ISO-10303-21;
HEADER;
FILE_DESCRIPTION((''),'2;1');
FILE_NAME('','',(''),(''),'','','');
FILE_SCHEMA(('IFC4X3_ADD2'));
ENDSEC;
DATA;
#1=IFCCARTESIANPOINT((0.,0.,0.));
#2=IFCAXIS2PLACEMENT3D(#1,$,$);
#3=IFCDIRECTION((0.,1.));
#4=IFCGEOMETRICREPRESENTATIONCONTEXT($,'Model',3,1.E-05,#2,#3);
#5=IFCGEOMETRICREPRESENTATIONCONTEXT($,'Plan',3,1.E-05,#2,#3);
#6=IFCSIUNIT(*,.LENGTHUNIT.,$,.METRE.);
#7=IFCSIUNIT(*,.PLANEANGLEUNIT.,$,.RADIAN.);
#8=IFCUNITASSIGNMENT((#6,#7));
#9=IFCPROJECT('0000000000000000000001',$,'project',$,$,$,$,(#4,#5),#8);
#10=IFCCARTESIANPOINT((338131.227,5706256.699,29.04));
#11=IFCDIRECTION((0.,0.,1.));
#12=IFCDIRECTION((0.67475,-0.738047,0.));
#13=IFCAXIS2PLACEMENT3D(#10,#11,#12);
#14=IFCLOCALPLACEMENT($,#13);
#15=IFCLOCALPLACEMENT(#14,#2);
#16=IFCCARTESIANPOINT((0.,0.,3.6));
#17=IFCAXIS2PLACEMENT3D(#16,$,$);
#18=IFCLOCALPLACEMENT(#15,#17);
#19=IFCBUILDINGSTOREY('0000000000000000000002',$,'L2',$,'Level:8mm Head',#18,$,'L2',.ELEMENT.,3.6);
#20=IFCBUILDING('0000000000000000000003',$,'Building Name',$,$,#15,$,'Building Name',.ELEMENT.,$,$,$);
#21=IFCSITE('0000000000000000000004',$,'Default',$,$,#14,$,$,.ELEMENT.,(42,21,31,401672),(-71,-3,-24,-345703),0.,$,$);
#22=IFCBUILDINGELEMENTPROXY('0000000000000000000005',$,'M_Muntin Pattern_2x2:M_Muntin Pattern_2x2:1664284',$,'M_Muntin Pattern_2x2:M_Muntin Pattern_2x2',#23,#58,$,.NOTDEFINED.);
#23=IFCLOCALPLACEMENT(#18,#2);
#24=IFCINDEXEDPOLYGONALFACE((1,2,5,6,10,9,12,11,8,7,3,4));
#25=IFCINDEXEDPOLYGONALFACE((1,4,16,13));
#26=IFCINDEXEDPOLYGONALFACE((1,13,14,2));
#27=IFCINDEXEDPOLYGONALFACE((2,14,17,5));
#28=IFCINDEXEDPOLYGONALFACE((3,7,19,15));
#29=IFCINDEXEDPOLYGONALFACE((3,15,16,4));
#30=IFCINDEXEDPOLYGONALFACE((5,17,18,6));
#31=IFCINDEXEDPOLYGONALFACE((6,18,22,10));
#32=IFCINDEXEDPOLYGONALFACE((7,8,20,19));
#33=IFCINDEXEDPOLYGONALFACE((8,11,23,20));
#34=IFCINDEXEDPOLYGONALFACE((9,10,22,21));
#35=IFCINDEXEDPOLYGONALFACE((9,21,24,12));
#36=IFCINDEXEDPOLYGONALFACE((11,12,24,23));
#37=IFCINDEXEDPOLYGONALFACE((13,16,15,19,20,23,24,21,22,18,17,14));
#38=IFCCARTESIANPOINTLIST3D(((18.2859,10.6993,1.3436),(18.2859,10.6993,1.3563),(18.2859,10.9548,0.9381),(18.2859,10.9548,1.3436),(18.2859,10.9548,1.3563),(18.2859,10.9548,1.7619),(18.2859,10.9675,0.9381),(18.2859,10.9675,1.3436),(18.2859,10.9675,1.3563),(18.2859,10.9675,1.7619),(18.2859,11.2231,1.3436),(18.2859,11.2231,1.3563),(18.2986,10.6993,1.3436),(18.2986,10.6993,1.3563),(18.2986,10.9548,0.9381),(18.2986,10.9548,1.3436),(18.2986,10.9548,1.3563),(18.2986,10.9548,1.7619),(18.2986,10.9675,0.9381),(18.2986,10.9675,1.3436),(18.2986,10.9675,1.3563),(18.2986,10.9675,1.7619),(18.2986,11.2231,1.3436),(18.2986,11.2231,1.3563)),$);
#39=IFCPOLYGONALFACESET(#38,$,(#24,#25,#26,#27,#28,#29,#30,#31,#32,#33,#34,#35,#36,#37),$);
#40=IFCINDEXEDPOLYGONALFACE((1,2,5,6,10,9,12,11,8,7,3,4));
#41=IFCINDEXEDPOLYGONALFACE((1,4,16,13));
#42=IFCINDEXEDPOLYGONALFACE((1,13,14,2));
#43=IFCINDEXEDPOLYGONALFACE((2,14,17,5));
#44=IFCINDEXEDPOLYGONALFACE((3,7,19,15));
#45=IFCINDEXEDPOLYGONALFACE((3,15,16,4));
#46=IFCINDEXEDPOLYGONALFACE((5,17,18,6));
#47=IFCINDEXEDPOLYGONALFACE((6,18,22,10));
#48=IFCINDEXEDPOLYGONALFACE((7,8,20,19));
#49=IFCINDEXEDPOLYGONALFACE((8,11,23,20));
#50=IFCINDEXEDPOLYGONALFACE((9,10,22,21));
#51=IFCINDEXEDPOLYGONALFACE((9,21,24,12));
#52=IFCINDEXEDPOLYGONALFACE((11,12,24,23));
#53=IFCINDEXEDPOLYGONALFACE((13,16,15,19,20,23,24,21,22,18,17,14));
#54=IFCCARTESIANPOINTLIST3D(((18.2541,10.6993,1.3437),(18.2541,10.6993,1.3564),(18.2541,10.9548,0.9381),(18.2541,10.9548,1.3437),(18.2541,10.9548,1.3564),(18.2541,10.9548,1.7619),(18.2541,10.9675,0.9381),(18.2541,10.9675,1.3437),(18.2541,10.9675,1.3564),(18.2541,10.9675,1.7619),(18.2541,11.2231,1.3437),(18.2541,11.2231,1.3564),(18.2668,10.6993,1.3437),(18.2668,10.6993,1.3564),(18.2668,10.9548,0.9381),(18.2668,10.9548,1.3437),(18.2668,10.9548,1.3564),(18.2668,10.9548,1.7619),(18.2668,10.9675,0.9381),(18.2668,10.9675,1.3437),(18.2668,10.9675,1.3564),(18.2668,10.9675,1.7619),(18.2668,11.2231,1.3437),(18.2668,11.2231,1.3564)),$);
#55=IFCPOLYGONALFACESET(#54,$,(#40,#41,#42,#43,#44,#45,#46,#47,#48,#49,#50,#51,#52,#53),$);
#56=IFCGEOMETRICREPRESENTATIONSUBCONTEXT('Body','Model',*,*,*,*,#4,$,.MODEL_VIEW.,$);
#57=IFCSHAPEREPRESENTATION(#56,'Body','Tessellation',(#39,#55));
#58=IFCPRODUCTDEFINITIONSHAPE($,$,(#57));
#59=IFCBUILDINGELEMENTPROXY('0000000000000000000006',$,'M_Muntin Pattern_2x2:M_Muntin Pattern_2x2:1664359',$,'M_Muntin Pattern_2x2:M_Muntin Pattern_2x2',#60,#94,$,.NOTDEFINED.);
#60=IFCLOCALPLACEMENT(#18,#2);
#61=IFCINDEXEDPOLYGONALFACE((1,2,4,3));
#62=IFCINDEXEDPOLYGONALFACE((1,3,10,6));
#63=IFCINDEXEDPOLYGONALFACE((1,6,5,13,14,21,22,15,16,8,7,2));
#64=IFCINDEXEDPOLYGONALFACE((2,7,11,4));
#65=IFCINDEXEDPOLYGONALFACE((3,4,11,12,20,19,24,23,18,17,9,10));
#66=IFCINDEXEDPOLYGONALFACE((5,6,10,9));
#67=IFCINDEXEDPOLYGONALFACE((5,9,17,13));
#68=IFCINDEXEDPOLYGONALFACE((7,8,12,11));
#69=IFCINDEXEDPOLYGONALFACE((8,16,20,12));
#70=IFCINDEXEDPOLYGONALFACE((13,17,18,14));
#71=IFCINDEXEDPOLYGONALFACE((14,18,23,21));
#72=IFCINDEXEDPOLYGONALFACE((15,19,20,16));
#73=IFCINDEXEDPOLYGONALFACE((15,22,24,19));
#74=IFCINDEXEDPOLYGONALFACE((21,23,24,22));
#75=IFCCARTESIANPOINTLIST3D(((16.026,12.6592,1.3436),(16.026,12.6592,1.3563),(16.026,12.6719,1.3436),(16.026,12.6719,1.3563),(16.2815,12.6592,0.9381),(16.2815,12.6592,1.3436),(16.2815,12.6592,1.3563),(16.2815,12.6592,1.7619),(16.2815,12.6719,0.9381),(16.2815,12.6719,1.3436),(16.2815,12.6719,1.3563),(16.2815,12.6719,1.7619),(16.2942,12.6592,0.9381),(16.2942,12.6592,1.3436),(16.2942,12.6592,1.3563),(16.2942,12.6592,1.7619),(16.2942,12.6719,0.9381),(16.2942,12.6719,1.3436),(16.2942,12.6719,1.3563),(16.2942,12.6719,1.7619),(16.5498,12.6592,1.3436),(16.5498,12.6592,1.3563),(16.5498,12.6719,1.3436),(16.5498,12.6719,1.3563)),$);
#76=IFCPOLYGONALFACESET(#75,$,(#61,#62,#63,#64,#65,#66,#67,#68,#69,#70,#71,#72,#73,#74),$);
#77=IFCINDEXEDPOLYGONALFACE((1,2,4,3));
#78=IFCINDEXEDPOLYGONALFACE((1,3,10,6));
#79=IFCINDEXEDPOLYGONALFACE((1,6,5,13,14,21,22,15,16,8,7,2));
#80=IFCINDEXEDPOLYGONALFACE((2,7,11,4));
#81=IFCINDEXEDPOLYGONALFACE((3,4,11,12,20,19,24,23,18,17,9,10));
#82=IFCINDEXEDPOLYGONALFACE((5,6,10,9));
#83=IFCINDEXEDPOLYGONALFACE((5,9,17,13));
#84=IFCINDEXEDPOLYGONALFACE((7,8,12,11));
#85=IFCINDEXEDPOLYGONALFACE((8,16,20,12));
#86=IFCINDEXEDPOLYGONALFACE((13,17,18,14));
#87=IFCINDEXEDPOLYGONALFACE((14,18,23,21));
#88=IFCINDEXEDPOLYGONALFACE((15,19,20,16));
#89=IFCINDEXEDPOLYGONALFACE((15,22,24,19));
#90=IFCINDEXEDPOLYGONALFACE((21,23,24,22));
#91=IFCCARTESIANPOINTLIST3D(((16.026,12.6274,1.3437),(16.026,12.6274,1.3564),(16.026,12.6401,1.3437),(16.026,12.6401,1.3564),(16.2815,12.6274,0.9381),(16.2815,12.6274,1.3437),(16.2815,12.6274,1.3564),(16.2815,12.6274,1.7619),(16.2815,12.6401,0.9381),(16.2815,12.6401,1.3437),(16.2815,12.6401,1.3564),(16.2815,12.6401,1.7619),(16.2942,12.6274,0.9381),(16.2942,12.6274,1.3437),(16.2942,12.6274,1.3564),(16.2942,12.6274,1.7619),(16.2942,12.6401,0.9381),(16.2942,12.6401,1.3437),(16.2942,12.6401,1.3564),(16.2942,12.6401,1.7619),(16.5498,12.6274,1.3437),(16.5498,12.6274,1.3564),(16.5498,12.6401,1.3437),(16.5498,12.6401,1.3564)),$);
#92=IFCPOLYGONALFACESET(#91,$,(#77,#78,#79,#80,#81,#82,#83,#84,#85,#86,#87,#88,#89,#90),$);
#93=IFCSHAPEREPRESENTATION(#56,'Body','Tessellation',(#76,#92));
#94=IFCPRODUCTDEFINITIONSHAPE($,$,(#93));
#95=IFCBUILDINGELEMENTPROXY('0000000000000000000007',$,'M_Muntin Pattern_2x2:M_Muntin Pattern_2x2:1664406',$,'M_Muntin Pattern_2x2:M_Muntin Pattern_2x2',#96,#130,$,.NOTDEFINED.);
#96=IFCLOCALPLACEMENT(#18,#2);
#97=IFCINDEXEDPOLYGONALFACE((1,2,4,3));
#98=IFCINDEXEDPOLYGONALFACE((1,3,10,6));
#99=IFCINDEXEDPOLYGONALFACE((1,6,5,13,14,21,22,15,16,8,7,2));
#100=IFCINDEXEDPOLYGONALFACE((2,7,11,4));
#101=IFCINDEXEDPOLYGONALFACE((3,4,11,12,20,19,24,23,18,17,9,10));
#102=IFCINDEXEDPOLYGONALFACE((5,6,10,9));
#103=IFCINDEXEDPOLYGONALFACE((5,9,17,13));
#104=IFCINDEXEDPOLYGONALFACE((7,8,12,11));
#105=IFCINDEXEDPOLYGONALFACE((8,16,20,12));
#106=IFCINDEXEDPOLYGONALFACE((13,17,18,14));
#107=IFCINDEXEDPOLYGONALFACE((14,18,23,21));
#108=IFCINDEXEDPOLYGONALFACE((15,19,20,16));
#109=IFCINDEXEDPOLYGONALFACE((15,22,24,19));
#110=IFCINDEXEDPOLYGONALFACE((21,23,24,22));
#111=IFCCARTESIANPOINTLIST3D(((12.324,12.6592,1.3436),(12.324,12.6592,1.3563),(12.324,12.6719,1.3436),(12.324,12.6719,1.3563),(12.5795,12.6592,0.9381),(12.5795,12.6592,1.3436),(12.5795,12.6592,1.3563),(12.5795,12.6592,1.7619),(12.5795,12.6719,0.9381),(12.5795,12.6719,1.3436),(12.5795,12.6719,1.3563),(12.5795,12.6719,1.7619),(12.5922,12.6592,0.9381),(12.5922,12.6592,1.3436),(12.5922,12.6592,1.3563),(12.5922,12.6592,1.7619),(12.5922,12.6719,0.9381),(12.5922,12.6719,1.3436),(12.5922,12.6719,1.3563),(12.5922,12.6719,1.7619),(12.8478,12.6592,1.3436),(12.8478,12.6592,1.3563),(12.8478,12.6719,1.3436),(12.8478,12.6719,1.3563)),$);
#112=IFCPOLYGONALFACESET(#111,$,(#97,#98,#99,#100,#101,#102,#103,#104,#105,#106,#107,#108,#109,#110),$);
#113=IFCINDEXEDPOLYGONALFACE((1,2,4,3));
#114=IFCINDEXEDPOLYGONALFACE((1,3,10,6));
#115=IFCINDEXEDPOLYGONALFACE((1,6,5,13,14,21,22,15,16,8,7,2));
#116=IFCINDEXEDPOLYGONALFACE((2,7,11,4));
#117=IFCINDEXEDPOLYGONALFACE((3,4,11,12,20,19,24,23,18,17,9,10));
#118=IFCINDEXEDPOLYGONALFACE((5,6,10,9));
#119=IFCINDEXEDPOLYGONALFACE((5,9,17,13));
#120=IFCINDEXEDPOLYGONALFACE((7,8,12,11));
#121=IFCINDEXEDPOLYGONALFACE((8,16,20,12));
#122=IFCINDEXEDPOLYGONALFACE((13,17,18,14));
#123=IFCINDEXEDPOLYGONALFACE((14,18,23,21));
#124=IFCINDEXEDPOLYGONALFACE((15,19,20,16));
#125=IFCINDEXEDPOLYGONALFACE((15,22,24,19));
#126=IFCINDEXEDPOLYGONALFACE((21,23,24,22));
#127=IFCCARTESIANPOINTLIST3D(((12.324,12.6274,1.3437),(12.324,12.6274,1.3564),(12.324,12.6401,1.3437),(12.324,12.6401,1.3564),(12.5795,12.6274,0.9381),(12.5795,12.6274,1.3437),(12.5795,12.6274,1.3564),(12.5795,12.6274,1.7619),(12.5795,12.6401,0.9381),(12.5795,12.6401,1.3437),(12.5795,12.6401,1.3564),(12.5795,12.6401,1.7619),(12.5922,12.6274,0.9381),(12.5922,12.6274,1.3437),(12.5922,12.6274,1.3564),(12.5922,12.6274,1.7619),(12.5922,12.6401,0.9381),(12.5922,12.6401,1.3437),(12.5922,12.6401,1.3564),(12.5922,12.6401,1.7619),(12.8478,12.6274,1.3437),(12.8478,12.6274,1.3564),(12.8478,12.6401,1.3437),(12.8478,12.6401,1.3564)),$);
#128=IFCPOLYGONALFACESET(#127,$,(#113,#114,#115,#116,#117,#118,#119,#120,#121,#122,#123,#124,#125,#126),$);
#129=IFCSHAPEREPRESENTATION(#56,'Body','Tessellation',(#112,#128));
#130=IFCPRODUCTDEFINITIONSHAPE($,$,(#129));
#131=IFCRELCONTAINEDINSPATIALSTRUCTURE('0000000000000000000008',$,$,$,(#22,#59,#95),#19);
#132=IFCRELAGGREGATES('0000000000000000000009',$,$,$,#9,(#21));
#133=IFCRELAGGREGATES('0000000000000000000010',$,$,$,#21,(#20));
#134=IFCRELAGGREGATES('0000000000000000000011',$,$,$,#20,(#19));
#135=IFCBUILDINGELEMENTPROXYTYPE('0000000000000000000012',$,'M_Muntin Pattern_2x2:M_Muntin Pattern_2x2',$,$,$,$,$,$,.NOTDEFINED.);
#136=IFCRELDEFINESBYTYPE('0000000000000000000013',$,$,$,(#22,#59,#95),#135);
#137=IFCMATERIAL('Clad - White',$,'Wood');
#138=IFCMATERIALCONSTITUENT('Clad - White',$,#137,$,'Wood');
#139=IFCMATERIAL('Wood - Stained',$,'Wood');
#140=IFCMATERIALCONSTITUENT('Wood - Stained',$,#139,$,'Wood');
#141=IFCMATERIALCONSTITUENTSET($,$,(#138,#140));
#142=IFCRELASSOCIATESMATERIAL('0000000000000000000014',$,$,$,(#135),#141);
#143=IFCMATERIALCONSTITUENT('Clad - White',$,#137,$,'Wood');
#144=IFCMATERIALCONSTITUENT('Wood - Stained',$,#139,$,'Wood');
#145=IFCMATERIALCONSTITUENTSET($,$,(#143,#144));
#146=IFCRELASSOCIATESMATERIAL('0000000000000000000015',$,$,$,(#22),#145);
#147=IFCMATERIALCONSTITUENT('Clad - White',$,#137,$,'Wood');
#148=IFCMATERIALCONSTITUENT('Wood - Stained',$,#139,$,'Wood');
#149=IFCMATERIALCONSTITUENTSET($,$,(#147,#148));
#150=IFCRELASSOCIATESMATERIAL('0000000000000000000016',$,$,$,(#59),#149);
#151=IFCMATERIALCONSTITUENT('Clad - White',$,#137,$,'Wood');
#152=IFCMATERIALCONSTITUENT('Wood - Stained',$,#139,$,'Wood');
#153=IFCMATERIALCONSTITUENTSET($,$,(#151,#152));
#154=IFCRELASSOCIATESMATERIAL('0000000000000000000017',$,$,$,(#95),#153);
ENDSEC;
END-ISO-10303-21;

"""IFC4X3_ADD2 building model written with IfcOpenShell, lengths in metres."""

from ifc_helpers import new_model, si_unit, direction, frame, origin, place, context, subcontext, project, spatial, polyline, outline, extrude, source, transform, mapped, material, constituent, constituent_set, type_object, type_shapes, element, save


model = new_model("IFC4X3_ADD2")

# Units and contexts
model_context = context("Model", 3, precision=1e-05, world=origin(), true_north=direction((0.0, 1.0)))
plan_context = context("Plan", 3, precision=1e-05, world=origin(), true_north=direction((0.0, 1.0)))
body_context = subcontext(model_context, "Body", "Model", "MODEL_VIEW")
ifc_project = project(units=[si_unit("LENGTHUNIT", "METRE"), si_unit("PLANEANGLEUNIT", "RADIAN")], contexts=[model_context, plan_context])

# Site, building, storey
site_placement = place(None, frame((338131.227, 5706256.699, 29.04), z_axis=(0.0, 0.0, 1.0), x_axis=(0.67475, -0.738047, 0.0)))
site = spatial("IfcSite", under=ifc_project, at=site_placement, Name="Default", CompositionType="ELEMENT", RefLatitude=(42, 21, 31, 401672), RefLongitude=(-71, -3, -24, -345703), RefElevation=0.0)
building_placement = place(site_placement, origin())
building = spatial("IfcBuilding", under=site, at=building_placement, Name="Building Name", LongName="Building Name", CompositionType="ELEMENT")
storey_placement = place(building_placement, frame((0.0, 0.0, 3.6)))
storey = spatial("IfcBuildingStorey", under=building, at=storey_placement, Name="L2", ObjectType="Level:8mm Head", LongName="L2", CompositionType="ELEMENT", Elevation=3.6)

# Building element proxies
ifc_material_1 = material(Name="Clad - White", Category="Wood")
ifc_material_2 = material(Name="Wood - Stained", Category="Wood")
ifc_constituent_1 = constituent(ifc_material_1, Name="Clad - White", Category="Wood")
ifc_constituent_2 = constituent(ifc_material_2, Name="Wood - Stained", Category="Wood")
ifc_constituent_set_1 = constituent_set(constituents=[ifc_constituent_1, ifc_constituent_2])
building_element_proxy_type = type_object("IfcBuildingElementProxyType", Name="M_Muntin Pattern_2x2:M_Muntin Pattern_2x2", PredefinedType="NOTDEFINED", material=ifc_constituent_set_1)
shared_shape = source(origin(), body_context, "Body", "SweptSolid", [
    extrude(outline(polyline([(0.0064, -0.0064), (0.4119, -0.0064), (0.4119, 0.0063), (0.0064, 0.0063), (0.0064, 0.2619), (-0.0063, 0.2619), (-0.0063, 0.0063), (-0.4119, 0.0063), (-0.4119, -0.0064), (-0.0063, -0.0064), (-0.0063, -0.2619), (0.0064, -0.2619), (0.0064, -0.0064)])), frame((0.0, -0.0222, 0.4119), z_axis=(0.0, 1.0, 0.0), x_axis=(0.0, 0.0, 1.0)), (0.0, 0.0, 1.0), 0.0127),
    extrude(outline(polyline([(0.0064, -0.0064), (0.4119, -0.0064), (0.4119, 0.0063), (0.0064, 0.0063), (0.0064, 0.2619), (-0.0063, 0.2619), (-0.0063, 0.0063), (-0.4119, 0.0063), (-0.4119, -0.0064), (-0.0063, -0.0064), (-0.0063, -0.2619), (0.0064, -0.2619), (0.0064, -0.0064)])), frame((0.0, 0.0095, 0.4119), z_axis=(0.0, 1.0, 0.0), x_axis=(0.0, 0.0, 1.0)), (0.0, 0.0, 1.0), 0.0127),
])
type_shapes(building_element_proxy_type, [shared_shape])
ifc_constituent_3 = constituent(ifc_material_1, Name="Clad - White", Category="Wood")
ifc_constituent_4 = constituent(ifc_material_2, Name="Wood - Stained", Category="Wood")
ifc_constituent_set_2 = constituent_set(constituents=[ifc_constituent_3, ifc_constituent_4])
proxy_1_placement = place(storey_placement, frame((18.2763, 10.9612, 0.9381), z_axis=(0.0, 0.0, 1.0), x_axis=(0.0, 1.0, 0.0)))
element("IfcBuildingElementProxy", 1, at=proxy_1_placement, inside=storey, type_object=building_element_proxy_type, material=ifc_constituent_set_2, Name="M_Muntin Pattern_2x2:M_Muntin Pattern_2x2:1664284", ObjectType="M_Muntin Pattern_2x2:M_Muntin Pattern_2x2", PredefinedType="NOTDEFINED", context=body_context, shape_type="MappedRepresentation", body=[
    mapped(shared_shape, transform((0.0, 0.0, 0.0), scale=1.0)),
])
ifc_constituent_5 = constituent(ifc_material_1, Name="Clad - White", Category="Wood")
ifc_constituent_6 = constituent(ifc_material_2, Name="Wood - Stained", Category="Wood")
ifc_constituent_set_3 = constituent_set(constituents=[ifc_constituent_5, ifc_constituent_6])
proxy_2_placement = place(storey_placement, frame((16.2879, 12.6497, 0.9381), z_axis=(0.0, 0.0, 1.0), x_axis=(-1.0, 0.0, 0.0)))
element("IfcBuildingElementProxy", 2, at=proxy_2_placement, inside=storey, type_object=building_element_proxy_type, material=ifc_constituent_set_3, Name="M_Muntin Pattern_2x2:M_Muntin Pattern_2x2:1664359", ObjectType="M_Muntin Pattern_2x2:M_Muntin Pattern_2x2", PredefinedType="NOTDEFINED", context=body_context, shape_type="MappedRepresentation", body=[
    mapped(shared_shape, transform((0.0, 0.0, 0.0), scale=1.0)),
])
ifc_constituent_7 = constituent(ifc_material_1, Name="Clad - White", Category="Wood")
ifc_constituent_8 = constituent(ifc_material_2, Name="Wood - Stained", Category="Wood")
ifc_constituent_set_4 = constituent_set(constituents=[ifc_constituent_7, ifc_constituent_8])
proxy_3_placement = place(storey_placement, frame((12.5859, 12.6497, 0.9381), z_axis=(0.0, 0.0, 1.0), x_axis=(-1.0, 0.0, 0.0)))
element("IfcBuildingElementProxy", 3, at=proxy_3_placement, inside=storey, type_object=building_element_proxy_type, material=ifc_constituent_set_4, Name="M_Muntin Pattern_2x2:M_Muntin Pattern_2x2:1664406", ObjectType="M_Muntin Pattern_2x2:M_Muntin Pattern_2x2", PredefinedType="NOTDEFINED", context=body_context, shape_type="MappedRepresentation", body=[
    mapped(shared_shape, transform((0.0, 0.0, 0.0), scale=1.0)),
])

save(model, "model.ifc")
